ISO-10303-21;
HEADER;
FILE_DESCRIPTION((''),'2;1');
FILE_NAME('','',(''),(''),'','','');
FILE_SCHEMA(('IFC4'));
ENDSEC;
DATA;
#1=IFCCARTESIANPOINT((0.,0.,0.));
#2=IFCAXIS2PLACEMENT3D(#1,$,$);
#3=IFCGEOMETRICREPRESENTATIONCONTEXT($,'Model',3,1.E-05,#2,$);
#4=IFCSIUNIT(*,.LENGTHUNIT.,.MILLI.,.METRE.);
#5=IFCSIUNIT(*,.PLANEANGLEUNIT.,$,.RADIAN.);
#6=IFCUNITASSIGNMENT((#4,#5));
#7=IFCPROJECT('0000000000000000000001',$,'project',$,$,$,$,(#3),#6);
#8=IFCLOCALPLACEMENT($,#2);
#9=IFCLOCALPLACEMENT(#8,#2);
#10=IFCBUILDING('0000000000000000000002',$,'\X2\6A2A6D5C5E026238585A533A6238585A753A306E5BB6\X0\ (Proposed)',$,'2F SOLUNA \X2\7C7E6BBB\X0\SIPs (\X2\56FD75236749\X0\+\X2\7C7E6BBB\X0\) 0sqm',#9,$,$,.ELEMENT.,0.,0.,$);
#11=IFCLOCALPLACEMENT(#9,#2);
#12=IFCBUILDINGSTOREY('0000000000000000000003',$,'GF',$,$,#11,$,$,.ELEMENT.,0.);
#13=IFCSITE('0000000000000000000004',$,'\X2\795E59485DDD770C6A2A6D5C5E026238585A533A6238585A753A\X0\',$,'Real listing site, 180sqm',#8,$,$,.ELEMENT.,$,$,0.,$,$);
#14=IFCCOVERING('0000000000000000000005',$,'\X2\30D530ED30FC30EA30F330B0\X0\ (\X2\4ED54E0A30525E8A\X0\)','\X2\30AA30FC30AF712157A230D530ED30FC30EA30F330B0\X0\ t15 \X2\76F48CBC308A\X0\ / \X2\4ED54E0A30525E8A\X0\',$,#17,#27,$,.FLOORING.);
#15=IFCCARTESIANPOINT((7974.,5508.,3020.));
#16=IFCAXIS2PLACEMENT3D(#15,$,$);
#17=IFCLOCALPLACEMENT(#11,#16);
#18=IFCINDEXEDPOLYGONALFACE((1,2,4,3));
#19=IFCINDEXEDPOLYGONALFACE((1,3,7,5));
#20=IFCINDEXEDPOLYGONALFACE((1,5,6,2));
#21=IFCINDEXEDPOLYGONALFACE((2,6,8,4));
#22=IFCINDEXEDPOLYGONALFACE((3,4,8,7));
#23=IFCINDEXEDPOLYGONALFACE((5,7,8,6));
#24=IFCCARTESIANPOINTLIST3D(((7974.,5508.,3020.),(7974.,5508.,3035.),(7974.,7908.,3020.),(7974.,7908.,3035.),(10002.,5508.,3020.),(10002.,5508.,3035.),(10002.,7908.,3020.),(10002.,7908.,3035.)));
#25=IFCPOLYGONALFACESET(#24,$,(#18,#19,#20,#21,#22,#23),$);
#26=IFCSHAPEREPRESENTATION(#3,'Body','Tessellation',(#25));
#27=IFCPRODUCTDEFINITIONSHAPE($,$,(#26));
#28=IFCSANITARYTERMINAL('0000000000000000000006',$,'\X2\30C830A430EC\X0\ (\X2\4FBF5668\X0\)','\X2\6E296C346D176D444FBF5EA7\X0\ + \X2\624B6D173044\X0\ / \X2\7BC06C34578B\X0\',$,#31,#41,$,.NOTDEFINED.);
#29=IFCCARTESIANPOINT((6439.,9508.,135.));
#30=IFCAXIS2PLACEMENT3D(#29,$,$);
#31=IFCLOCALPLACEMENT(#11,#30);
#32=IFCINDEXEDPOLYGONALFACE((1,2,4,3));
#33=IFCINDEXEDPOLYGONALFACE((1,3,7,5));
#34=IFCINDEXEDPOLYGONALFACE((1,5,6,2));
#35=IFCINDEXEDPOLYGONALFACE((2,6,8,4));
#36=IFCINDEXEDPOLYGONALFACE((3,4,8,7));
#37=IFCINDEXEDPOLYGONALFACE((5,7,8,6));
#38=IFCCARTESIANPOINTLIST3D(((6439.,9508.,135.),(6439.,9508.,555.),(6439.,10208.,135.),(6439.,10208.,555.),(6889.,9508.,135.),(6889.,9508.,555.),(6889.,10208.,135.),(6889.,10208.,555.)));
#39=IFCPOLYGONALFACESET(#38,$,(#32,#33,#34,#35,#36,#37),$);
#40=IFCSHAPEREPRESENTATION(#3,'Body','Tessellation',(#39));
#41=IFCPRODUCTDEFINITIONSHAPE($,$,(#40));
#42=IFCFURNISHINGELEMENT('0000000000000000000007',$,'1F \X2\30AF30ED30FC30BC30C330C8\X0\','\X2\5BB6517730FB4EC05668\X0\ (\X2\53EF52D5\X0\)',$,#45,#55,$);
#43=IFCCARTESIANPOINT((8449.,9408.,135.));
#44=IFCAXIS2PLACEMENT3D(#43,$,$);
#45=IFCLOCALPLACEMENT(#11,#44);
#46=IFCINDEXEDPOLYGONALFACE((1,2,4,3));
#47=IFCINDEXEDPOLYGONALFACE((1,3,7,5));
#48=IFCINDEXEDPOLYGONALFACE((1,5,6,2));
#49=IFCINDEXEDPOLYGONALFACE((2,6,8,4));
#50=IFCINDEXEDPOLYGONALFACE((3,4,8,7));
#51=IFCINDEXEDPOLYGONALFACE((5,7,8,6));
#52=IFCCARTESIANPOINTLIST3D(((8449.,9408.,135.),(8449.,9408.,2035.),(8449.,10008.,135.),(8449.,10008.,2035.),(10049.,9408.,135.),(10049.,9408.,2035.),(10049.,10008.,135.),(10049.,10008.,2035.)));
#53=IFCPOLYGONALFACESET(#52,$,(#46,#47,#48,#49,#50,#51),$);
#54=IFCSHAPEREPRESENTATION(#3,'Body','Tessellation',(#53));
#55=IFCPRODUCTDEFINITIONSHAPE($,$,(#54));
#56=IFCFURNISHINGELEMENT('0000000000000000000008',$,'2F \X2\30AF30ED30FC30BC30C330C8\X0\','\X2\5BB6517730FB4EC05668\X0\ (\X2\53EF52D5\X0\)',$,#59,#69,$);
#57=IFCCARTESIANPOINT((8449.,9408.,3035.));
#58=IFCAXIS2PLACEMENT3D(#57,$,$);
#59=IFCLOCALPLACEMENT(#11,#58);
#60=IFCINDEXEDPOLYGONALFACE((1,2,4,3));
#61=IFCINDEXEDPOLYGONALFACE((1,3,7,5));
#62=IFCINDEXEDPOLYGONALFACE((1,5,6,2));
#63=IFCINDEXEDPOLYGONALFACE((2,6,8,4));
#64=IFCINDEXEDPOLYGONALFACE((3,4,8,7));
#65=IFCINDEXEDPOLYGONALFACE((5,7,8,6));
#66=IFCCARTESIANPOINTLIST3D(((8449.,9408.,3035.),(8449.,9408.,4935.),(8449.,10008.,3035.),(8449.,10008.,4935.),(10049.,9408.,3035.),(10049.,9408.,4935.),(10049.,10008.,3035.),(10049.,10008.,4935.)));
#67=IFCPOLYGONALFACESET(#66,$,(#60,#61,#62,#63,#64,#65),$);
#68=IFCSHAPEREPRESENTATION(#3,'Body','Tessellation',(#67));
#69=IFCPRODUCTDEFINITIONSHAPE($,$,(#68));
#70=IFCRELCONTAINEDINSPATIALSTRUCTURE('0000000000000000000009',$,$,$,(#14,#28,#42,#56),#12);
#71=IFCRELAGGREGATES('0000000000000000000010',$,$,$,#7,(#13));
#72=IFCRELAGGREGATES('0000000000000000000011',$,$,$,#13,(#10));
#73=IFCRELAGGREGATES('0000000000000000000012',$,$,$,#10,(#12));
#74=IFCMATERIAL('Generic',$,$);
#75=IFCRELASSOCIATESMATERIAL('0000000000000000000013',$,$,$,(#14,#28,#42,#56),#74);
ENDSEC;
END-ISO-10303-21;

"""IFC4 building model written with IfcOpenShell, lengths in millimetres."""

from ifc_helpers import new_model, si_unit, frame, frame_2d, origin, place, context, project, spatial, rectangle, extrude, material, element, save


model = new_model("IFC4")

# Units and contexts
model_context = context("Model", 3, precision=1e-05, world=origin())
ifc_project = project(units=[si_unit("LENGTHUNIT", "METRE", prefix="MILLI"), si_unit("PLANEANGLEUNIT", "RADIAN")], contexts=[model_context])

# Site, building, storey
site_placement = place(None, origin())
site = spatial("IfcSite", under=ifc_project, at=site_placement, Name="神奈川県横浜市戸塚区戸塚町", ObjectType="Real listing site, 180sqm", CompositionType="ELEMENT", RefElevation=0.0)
building_placement = place(site_placement, origin())
building = spatial("IfcBuilding", under=site, at=building_placement, Name="横浜市戸塚区戸塚町の家 (Proposed)", ObjectType="2F SOLUNA 籾殻SIPs (国産杉+籾殻) 0sqm", CompositionType="ELEMENT", ElevationOfRefHeight=0.0, ElevationOfTerrain=0.0)
storey_placement = place(building_placement, origin())
storey = spatial("IfcBuildingStorey", under=building, at=storey_placement, Name="GF", CompositionType="ELEMENT", Elevation=0.0)

# Covering
ifc_material_1 = material(Name="Generic")
covering_1_placement = place(storey_placement, frame((7974.0, 5508.0, 3020.0)))
element("IfcCovering", 1, at=covering_1_placement, inside=storey, material=ifc_material_1, Name="フローリング (仕上げ床)", Description="オーク無垢フローリング t15 直貼り / 仕上げ床", PredefinedType="FLOORING", context=model_context, shape_type="SweptSolid", body=[
    extrude(rectangle(XDim=2028.0, YDim=2400.0, at=frame_2d((1014.0, 1200.0))), frame((7974.0, 5508.0, 3020.0)), (0.0, 0.0, 1.0), 15.0),
])

# Sanitary terminal
sanitary_terminal_placement = place(storey_placement, frame((6439.0, 9508.0, 135.0)))
element("IfcSanitaryTerminal", 2, at=sanitary_terminal_placement, inside=storey, material=ifc_material_1, Name="トイレ (便器)", Description="温水洗浄便座 + 手洗い / 節水型", PredefinedType="NOTDEFINED", context=model_context, shape_type="SweptSolid", body=[
    extrude(rectangle(XDim=450.0, YDim=700.0, at=frame_2d((225.0, 350.0))), frame((6439.0, 9508.0, 135.0)), (0.0, 0.0, 1.0), 420.0),
])

# Furnishing elements
furnishing_1_placement = place(storey_placement, frame((8449.0, 9408.0, 135.0)))
element("IfcFurnishingElement", 3, at=furnishing_1_placement, inside=storey, material=ifc_material_1, Name="1F クローゼット", Description="家具・什器 (可動)", context=model_context, shape_type="SweptSolid", body=[
    extrude(rectangle(XDim=1600.0, YDim=600.0, at=frame_2d((800.0, 300.0))), frame((8449.0, 9408.0, 135.0)), (0.0, 0.0, 1.0), 1900.0),
])
furnishing_2_placement = place(storey_placement, frame((8449.0, 9408.0, 3035.0)))
element("IfcFurnishingElement", 4, at=furnishing_2_placement, inside=storey, material=ifc_material_1, Name="2F クローゼット", Description="家具・什器 (可動)", context=model_context, shape_type="SweptSolid", body=[
    extrude(rectangle(XDim=1600.0, YDim=600.0, at=frame_2d((800.0, 300.0))), frame((8449.0, 9408.0, 3035.0)), (0.0, 0.0, 1.0), 1900.0),
])

save(model, "model.ifc")
